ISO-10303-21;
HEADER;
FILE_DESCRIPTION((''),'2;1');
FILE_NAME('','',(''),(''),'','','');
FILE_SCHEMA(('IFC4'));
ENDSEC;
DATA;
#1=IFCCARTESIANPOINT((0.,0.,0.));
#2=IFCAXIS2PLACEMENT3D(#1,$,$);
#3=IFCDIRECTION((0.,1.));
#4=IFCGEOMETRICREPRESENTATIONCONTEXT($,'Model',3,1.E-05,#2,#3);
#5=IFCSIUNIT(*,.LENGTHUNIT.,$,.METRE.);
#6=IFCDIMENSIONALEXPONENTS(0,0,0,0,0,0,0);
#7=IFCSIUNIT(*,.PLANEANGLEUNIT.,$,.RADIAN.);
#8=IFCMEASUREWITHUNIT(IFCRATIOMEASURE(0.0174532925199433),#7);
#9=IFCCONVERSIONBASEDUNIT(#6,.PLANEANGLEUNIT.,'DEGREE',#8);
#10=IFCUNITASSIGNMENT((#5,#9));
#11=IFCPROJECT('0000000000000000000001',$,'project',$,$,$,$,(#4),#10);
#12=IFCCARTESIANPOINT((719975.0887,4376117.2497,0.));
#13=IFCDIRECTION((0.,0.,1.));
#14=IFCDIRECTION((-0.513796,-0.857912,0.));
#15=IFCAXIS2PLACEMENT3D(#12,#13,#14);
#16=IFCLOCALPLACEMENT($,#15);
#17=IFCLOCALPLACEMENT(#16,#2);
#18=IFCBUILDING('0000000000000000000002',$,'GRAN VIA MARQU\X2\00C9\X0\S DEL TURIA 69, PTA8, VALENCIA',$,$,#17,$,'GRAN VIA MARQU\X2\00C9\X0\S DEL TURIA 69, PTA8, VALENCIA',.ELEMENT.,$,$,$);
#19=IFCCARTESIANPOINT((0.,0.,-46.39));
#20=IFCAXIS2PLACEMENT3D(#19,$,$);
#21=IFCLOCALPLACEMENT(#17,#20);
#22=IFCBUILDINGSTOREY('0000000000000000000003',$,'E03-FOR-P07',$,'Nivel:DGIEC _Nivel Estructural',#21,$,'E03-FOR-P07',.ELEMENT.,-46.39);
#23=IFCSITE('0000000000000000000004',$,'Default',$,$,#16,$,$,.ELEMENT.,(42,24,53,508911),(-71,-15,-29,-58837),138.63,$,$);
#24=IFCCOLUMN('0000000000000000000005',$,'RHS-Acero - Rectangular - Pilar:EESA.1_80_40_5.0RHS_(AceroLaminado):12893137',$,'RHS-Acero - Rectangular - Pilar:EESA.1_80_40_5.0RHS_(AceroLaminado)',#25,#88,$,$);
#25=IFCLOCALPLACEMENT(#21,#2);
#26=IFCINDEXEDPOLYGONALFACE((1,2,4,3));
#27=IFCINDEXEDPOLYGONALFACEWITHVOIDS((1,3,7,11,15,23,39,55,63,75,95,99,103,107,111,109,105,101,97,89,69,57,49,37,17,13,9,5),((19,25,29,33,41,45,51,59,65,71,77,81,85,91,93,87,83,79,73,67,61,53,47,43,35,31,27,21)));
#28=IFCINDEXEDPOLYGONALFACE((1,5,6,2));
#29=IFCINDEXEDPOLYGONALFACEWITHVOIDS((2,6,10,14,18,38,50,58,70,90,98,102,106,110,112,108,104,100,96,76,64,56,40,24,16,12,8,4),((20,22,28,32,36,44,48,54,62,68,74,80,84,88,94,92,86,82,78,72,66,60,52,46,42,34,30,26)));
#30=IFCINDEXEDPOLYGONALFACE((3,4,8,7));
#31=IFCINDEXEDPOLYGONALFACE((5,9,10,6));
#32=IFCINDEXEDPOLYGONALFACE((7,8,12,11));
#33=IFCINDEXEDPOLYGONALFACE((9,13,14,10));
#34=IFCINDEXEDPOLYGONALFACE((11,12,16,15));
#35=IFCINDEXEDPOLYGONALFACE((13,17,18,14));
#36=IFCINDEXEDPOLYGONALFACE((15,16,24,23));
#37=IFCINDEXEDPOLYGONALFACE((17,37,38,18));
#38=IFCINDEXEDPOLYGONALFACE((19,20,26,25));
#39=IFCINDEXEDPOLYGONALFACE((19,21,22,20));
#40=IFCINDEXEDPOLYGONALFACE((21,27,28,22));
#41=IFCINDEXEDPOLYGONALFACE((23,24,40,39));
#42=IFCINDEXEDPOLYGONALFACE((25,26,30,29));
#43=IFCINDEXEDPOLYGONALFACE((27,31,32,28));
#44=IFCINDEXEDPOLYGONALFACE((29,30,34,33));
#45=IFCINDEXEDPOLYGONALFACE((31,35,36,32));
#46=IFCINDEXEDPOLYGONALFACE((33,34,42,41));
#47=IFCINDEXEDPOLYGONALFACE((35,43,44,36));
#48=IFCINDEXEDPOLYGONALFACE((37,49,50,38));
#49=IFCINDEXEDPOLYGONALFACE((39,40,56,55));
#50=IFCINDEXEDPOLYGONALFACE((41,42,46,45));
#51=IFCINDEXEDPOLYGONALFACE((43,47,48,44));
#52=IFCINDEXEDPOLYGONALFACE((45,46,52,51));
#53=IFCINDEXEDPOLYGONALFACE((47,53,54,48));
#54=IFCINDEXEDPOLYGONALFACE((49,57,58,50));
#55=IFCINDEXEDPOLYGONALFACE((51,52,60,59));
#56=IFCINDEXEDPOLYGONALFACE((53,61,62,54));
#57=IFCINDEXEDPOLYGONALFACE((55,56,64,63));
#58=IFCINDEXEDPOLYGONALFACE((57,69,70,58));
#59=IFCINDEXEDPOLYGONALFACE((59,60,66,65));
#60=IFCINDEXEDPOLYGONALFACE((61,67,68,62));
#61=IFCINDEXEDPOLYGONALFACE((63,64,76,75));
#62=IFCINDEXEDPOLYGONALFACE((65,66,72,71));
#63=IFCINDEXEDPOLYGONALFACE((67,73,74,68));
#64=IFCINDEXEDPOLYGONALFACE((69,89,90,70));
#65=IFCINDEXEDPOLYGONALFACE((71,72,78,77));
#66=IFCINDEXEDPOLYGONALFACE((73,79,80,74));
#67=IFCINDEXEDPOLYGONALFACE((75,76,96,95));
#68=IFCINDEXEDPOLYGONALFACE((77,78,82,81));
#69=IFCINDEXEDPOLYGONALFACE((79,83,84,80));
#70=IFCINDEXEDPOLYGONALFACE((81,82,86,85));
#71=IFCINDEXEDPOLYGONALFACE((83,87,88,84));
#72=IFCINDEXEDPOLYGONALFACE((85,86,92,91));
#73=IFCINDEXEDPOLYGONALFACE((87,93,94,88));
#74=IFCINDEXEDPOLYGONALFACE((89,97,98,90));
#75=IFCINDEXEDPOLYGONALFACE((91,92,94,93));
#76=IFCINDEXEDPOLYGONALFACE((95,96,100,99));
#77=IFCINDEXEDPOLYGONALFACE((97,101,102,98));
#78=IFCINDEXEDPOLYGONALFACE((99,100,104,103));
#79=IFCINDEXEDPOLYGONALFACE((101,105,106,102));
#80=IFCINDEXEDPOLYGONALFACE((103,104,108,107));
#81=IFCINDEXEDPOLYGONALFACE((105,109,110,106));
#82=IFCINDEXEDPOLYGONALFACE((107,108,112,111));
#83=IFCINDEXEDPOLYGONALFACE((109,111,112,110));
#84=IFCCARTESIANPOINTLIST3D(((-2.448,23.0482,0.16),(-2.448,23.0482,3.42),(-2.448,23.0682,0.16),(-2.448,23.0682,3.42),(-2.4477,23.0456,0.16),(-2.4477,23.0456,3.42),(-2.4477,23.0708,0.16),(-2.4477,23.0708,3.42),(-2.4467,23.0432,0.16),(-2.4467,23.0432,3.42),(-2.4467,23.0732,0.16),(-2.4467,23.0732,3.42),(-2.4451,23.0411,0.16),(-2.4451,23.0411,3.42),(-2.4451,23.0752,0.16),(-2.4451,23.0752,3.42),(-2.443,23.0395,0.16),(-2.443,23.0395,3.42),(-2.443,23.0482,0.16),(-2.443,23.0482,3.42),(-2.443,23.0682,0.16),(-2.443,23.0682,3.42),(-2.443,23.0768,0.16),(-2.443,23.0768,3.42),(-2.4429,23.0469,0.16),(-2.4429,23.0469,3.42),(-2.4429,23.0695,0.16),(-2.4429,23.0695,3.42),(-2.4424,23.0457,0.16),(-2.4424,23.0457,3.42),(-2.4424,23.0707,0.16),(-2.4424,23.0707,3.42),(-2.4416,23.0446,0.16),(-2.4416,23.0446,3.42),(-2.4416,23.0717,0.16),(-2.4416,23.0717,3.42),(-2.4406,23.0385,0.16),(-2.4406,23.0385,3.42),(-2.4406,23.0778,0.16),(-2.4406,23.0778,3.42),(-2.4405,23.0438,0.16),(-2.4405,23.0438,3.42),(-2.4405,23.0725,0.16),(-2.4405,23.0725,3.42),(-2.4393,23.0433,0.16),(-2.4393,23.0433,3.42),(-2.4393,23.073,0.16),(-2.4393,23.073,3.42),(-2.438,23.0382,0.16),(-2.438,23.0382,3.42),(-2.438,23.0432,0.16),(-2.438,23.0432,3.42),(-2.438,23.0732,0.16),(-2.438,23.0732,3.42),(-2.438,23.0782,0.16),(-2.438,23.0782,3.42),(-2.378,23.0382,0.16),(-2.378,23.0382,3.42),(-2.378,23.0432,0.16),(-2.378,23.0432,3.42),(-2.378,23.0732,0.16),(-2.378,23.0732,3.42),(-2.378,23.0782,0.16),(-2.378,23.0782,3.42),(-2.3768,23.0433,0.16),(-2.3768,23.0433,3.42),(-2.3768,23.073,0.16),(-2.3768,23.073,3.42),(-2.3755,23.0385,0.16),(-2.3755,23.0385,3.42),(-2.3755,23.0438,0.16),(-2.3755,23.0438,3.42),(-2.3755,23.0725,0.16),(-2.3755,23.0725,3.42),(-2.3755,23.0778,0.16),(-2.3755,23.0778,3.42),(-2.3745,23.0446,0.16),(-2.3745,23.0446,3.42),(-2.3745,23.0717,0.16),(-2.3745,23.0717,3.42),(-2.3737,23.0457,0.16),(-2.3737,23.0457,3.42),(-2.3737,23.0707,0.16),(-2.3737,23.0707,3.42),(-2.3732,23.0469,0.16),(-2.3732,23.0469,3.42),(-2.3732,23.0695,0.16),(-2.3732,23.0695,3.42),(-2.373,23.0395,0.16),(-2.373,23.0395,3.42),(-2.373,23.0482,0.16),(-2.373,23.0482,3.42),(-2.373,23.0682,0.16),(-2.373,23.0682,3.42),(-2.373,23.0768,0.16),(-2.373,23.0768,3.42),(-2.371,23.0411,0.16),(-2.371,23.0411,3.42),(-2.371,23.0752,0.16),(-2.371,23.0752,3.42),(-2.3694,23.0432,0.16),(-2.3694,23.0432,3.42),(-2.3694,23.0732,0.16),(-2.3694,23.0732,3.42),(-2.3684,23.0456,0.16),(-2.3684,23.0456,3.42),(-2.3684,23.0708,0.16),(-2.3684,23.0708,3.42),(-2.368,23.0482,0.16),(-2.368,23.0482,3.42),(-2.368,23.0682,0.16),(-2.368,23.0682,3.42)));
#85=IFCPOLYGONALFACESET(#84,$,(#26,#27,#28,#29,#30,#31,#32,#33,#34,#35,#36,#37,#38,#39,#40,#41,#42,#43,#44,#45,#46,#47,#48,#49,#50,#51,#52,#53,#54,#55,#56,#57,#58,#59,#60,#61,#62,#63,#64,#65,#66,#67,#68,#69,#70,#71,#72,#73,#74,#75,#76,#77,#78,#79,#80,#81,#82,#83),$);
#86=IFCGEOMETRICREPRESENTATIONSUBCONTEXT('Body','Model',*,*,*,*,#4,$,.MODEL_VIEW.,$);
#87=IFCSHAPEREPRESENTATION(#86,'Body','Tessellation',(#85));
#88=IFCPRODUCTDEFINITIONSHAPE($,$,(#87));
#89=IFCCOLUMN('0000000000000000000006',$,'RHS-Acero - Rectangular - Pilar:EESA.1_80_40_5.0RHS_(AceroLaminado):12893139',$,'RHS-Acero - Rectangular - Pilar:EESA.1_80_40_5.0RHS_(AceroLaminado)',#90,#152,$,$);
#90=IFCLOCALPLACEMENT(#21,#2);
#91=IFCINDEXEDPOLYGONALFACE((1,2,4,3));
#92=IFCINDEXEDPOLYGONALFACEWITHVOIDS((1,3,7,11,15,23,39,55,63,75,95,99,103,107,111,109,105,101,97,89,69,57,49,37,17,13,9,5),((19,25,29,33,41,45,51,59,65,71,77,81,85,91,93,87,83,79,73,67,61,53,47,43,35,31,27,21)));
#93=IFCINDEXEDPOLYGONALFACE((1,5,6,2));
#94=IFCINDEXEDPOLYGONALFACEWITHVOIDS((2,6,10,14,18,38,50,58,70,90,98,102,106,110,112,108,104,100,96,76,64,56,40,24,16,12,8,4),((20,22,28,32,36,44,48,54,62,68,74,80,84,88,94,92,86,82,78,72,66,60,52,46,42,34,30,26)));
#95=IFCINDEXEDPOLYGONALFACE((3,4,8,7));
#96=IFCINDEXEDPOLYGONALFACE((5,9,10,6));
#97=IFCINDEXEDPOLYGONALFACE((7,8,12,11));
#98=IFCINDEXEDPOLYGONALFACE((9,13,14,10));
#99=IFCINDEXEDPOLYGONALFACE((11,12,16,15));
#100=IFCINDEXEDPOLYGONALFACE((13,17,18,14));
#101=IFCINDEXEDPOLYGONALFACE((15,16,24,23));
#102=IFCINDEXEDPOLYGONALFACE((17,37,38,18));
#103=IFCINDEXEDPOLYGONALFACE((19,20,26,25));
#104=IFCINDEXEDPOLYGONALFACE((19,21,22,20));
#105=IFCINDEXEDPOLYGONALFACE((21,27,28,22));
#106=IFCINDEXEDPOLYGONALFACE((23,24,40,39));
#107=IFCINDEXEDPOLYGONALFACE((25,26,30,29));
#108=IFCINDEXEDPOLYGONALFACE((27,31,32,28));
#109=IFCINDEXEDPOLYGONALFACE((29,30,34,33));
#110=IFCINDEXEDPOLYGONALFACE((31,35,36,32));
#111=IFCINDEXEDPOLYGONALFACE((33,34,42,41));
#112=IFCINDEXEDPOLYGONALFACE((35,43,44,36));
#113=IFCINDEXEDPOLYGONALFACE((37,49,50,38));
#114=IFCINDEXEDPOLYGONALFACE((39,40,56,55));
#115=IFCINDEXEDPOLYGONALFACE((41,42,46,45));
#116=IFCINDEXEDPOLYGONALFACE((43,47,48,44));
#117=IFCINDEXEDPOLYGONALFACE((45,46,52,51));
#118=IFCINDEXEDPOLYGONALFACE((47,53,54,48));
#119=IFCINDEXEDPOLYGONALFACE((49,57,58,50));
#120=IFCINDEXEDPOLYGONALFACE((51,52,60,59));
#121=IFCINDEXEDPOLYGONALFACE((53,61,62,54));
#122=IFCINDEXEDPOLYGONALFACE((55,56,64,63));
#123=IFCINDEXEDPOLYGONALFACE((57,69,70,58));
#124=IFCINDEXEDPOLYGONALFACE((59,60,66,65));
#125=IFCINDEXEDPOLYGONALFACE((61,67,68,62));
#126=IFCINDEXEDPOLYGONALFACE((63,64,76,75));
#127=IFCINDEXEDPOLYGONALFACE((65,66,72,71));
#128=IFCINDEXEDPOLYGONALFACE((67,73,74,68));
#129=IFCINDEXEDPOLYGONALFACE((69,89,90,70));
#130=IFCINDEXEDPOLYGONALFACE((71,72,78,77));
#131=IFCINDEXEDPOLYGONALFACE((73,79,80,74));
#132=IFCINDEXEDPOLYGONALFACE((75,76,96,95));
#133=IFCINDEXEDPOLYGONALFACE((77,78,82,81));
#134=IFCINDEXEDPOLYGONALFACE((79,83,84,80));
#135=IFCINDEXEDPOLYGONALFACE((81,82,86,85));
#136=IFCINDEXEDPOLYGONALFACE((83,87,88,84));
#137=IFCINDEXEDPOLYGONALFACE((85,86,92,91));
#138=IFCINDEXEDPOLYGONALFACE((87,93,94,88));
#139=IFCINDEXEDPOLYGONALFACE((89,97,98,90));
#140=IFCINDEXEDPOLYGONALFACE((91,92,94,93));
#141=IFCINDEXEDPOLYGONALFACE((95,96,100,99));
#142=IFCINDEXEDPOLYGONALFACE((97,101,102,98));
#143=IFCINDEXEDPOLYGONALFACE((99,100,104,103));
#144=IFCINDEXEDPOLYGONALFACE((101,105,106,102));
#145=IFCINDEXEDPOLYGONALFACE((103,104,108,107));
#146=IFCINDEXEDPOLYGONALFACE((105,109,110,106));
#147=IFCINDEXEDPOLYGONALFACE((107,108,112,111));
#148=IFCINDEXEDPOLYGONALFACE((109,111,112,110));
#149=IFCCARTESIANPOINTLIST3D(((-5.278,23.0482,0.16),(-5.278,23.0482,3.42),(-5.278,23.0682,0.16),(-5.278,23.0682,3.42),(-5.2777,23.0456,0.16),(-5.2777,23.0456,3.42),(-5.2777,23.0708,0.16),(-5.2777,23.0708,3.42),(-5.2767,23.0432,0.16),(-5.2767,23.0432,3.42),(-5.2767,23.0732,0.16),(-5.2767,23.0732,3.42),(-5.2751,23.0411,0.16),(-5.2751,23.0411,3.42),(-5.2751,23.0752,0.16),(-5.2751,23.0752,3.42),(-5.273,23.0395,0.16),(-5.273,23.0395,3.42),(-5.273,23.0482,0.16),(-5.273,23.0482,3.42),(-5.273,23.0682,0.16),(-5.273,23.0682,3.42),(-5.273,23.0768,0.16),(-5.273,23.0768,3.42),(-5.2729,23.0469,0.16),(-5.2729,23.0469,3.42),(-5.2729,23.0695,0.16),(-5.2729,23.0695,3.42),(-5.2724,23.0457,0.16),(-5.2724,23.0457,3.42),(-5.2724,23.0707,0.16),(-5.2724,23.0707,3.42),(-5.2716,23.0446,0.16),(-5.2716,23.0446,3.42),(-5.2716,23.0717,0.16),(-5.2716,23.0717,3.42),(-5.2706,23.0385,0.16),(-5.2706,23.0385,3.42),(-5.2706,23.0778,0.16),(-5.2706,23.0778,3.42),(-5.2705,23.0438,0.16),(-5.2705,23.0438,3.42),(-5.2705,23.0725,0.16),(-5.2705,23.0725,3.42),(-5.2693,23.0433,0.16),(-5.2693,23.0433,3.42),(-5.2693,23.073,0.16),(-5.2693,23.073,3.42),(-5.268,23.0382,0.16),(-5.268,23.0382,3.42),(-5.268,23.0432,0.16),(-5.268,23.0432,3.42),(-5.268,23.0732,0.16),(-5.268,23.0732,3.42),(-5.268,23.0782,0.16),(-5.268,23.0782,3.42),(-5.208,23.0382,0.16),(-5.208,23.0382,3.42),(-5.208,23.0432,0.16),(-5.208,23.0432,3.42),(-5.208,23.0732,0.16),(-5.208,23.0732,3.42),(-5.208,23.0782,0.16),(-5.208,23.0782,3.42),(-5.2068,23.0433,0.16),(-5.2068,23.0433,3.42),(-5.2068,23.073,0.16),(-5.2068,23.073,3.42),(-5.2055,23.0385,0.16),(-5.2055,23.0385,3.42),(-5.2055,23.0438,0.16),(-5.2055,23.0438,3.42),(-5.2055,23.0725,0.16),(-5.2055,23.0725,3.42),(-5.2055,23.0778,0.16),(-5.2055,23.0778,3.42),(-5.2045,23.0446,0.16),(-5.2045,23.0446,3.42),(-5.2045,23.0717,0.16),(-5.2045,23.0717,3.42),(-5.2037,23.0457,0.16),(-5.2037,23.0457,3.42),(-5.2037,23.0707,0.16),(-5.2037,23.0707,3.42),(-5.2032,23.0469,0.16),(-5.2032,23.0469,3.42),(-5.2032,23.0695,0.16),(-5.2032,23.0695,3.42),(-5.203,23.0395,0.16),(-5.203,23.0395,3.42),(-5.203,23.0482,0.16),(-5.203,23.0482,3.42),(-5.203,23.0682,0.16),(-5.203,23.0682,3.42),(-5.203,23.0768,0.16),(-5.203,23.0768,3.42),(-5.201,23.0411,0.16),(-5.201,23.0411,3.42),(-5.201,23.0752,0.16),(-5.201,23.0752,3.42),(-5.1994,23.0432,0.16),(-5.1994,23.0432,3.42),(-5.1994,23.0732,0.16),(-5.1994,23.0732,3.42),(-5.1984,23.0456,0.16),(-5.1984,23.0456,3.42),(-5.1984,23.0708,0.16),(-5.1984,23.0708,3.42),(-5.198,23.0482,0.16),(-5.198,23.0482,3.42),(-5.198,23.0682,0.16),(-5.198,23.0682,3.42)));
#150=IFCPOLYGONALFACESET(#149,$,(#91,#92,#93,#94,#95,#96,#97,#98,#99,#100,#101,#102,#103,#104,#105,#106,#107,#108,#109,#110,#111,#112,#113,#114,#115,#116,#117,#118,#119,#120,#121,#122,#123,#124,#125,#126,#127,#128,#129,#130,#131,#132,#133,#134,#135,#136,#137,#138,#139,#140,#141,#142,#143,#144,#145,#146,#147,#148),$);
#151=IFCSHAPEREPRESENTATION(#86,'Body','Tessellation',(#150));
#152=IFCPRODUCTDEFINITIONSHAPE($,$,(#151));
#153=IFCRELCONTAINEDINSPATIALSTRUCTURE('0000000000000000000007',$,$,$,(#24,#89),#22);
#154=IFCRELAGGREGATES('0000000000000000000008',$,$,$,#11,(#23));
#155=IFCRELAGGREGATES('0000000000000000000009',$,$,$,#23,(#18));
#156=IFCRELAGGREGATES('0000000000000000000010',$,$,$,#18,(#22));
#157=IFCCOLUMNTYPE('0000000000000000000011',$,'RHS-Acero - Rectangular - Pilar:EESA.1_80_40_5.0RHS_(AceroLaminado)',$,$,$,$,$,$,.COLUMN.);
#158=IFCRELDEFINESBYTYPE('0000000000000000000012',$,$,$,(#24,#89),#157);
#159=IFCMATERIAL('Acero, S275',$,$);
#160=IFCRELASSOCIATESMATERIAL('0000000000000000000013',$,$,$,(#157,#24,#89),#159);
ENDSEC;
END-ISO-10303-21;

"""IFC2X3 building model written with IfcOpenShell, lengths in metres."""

from ifc_helpers import new_model, entity, si_unit, converted_unit, direction, frame, frame_2d, origin, place, context, subcontext, project, spatial, polyline, circle_curve, parameter, trimmed, segment, composite_curve, outline, extrude, source, transform, mapped, material, type_object, type_shapes, element, save


model = new_model("IFC2X3")

# Units and contexts
model_context = context("Model", 3, precision=1e-05, world=origin(), true_north=direction((0.0, 1.0)))
body_context = subcontext(model_context, "Body", "Model", "MODEL_VIEW")
ifc_project = project(units=[si_unit("LENGTHUNIT", "METRE"), converted_unit("PLANEANGLEUNIT", "DEGREE", entity("IfcRatioMeasure", 0.0174532925199433), si_unit("PLANEANGLEUNIT", "RADIAN"), dimensions=[0, 0, 0, 0, 0, 0, 0])], contexts=[model_context])

# Site, building, storey
site_placement = place(None, frame((719975.0887, 4376117.2497, 0.0), z_axis=(0.0, 0.0, 1.0), x_axis=(-0.513796, -0.857912, 0.0)))
site = spatial("IfcSite", under=ifc_project, at=site_placement, Name="Default", CompositionType="ELEMENT", RefLatitude=(42, 24, 53, 508911), RefLongitude=(-71, -15, -29, -58837), RefElevation=138.63)
building_placement = place(site_placement, origin())
building = spatial("IfcBuilding", under=site, at=building_placement, Name="GRAN VIA MARQUÉS DEL TURIA 69, PTA8, VALENCIA", LongName="GRAN VIA MARQUÉS DEL TURIA 69, PTA8, VALENCIA", CompositionType="ELEMENT")
storey_placement = place(building_placement, frame((0.0, 0.0, -46.39)))
storey = spatial("IfcBuildingStorey", under=building, at=storey_placement, Name="E03-FOR-P07", ObjectType="Nivel:DGIEC _Nivel Estructural", LongName="E03-FOR-P07", CompositionType="ELEMENT", Elevation=-46.39)

# Columns
ifc_material = material(Name="Acero, S275")
column_type_1 = type_object("IfcColumnType", Name="RHS-Acero - Rectangular - Pilar:EESA.1_80_40_5.0RHS_(AceroLaminado)", PredefinedType="COLUMN", material=ifc_material)
shared_shape_1 = source(origin(), body_context, "Body", "SweptSolid", [
    extrude(outline(composite_curve([segment(polyline([(-0.01, -0.04), (0.01, -0.04)]), True, "CONTINUOUS"), segment(trimmed(circle_curve(frame_2d((0.01, -0.03), x_axis=(-1.0, 0.0)), 0.01), [parameter(90.0)], [parameter(180.0)], True, "PARAMETER"), True, "CONTINUOUS"), segment(polyline([(0.02, -0.03), (0.02, 0.03)]), True, "CONTINUOUS"), segment(trimmed(circle_curve(frame_2d((0.01, 0.03), x_axis=(-1.0, 0.0)), 0.01), [parameter(180.0)], [parameter(270.0)], True, "PARAMETER"), True, "CONTINUOUS"), segment(polyline([(0.01, 0.04), (-0.01, 0.04)]), True, "CONTINUOUS"), segment(trimmed(circle_curve(frame_2d((-0.01, 0.03), x_axis=(-1.0, 0.0)), 0.01), [parameter(270.0)], [parameter(360.0)], True, "PARAMETER"), True, "CONTINUOUS"), segment(polyline([(-0.02, 0.03), (-0.02, -0.03)]), True, "CONTINUOUS"), segment(trimmed(circle_curve(frame_2d((-0.01, -0.03), x_axis=(-1.0, 0.0)), 0.01), [parameter(360.0)], [parameter(90.0)], True, "PARAMETER"), True, "CONTINUOUS")], self_intersect=False), holes=[composite_curve([segment(trimmed(circle_curve(frame_2d((-0.01, -0.03), x_axis=(-1.0, 0.0)), 0.005), [parameter(0.0)], [parameter(90.0)], True, "PARAMETER"), False, "CONTINUOUS"), segment(polyline([(-0.015, -0.03), (-0.015, 0.03)]), True, "CONTINUOUS"), segment(trimmed(circle_curve(frame_2d((-0.01, 0.03), x_axis=(-1.0, 0.0)), 0.005), [parameter(270.0)], [parameter(0.0)], True, "PARAMETER"), False, "CONTINUOUS"), segment(polyline([(-0.01, 0.035), (0.01, 0.035)]), True, "CONTINUOUS"), segment(trimmed(circle_curve(frame_2d((0.01, 0.03), x_axis=(-1.0, 0.0)), 0.005), [parameter(180.0)], [parameter(270.0)], True, "PARAMETER"), False, "CONTINUOUS"), segment(polyline([(0.015, 0.03), (0.015, -0.03)]), True, "CONTINUOUS"), segment(trimmed(circle_curve(frame_2d((0.01, -0.03), x_axis=(-1.0, 0.0)), 0.005), [parameter(90.0)], [parameter(180.0)], True, "PARAMETER"), False, "CONTINUOUS"), segment(polyline([(0.01, -0.035), (-0.01, -0.035)]), True, "CONTINUOUS")], self_intersect=False)]), frame((0.0, 0.0, -46.23), z_axis=(0.0, 0.0, 1.0), x_axis=(-1.0, 0.0, 0.0)), (0.0, 0.0, 1.0), 3.26),
])
type_shapes(column_type_1, [shared_shape_1])
for number, where, z_axis, x_axis, name in (
    (1, (-2.408, 23.0582, 46.39), (0.0, 0.0, 1.0), (0.0, 1.0, 0.0), "RHS-Acero - Rectangular - Pilar:EESA.1_80_40_5.0RHS_(AceroLaminado):12893137"),
    (2, (-5.238, 23.0582, 46.39), (0.0, 0.0, 1.0), (0.0, 1.0, 0.0), "RHS-Acero - Rectangular - Pilar:EESA.1_80_40_5.0RHS_(AceroLaminado):12893139"),
):
    element("IfcColumn", number, at=place(storey_placement, frame(where, z_axis=z_axis, x_axis=x_axis)), inside=storey, type_object=column_type_1, material=ifc_material, Name=name, ObjectType="RHS-Acero - Rectangular - Pilar:EESA.1_80_40_5.0RHS_(AceroLaminado)", context=body_context, shape_type="MappedRepresentation", body=[
        mapped(shared_shape_1, transform((0.0, 0.0, 0.0), scale=1.0)),
    ])

save(model, "model.ifc")
